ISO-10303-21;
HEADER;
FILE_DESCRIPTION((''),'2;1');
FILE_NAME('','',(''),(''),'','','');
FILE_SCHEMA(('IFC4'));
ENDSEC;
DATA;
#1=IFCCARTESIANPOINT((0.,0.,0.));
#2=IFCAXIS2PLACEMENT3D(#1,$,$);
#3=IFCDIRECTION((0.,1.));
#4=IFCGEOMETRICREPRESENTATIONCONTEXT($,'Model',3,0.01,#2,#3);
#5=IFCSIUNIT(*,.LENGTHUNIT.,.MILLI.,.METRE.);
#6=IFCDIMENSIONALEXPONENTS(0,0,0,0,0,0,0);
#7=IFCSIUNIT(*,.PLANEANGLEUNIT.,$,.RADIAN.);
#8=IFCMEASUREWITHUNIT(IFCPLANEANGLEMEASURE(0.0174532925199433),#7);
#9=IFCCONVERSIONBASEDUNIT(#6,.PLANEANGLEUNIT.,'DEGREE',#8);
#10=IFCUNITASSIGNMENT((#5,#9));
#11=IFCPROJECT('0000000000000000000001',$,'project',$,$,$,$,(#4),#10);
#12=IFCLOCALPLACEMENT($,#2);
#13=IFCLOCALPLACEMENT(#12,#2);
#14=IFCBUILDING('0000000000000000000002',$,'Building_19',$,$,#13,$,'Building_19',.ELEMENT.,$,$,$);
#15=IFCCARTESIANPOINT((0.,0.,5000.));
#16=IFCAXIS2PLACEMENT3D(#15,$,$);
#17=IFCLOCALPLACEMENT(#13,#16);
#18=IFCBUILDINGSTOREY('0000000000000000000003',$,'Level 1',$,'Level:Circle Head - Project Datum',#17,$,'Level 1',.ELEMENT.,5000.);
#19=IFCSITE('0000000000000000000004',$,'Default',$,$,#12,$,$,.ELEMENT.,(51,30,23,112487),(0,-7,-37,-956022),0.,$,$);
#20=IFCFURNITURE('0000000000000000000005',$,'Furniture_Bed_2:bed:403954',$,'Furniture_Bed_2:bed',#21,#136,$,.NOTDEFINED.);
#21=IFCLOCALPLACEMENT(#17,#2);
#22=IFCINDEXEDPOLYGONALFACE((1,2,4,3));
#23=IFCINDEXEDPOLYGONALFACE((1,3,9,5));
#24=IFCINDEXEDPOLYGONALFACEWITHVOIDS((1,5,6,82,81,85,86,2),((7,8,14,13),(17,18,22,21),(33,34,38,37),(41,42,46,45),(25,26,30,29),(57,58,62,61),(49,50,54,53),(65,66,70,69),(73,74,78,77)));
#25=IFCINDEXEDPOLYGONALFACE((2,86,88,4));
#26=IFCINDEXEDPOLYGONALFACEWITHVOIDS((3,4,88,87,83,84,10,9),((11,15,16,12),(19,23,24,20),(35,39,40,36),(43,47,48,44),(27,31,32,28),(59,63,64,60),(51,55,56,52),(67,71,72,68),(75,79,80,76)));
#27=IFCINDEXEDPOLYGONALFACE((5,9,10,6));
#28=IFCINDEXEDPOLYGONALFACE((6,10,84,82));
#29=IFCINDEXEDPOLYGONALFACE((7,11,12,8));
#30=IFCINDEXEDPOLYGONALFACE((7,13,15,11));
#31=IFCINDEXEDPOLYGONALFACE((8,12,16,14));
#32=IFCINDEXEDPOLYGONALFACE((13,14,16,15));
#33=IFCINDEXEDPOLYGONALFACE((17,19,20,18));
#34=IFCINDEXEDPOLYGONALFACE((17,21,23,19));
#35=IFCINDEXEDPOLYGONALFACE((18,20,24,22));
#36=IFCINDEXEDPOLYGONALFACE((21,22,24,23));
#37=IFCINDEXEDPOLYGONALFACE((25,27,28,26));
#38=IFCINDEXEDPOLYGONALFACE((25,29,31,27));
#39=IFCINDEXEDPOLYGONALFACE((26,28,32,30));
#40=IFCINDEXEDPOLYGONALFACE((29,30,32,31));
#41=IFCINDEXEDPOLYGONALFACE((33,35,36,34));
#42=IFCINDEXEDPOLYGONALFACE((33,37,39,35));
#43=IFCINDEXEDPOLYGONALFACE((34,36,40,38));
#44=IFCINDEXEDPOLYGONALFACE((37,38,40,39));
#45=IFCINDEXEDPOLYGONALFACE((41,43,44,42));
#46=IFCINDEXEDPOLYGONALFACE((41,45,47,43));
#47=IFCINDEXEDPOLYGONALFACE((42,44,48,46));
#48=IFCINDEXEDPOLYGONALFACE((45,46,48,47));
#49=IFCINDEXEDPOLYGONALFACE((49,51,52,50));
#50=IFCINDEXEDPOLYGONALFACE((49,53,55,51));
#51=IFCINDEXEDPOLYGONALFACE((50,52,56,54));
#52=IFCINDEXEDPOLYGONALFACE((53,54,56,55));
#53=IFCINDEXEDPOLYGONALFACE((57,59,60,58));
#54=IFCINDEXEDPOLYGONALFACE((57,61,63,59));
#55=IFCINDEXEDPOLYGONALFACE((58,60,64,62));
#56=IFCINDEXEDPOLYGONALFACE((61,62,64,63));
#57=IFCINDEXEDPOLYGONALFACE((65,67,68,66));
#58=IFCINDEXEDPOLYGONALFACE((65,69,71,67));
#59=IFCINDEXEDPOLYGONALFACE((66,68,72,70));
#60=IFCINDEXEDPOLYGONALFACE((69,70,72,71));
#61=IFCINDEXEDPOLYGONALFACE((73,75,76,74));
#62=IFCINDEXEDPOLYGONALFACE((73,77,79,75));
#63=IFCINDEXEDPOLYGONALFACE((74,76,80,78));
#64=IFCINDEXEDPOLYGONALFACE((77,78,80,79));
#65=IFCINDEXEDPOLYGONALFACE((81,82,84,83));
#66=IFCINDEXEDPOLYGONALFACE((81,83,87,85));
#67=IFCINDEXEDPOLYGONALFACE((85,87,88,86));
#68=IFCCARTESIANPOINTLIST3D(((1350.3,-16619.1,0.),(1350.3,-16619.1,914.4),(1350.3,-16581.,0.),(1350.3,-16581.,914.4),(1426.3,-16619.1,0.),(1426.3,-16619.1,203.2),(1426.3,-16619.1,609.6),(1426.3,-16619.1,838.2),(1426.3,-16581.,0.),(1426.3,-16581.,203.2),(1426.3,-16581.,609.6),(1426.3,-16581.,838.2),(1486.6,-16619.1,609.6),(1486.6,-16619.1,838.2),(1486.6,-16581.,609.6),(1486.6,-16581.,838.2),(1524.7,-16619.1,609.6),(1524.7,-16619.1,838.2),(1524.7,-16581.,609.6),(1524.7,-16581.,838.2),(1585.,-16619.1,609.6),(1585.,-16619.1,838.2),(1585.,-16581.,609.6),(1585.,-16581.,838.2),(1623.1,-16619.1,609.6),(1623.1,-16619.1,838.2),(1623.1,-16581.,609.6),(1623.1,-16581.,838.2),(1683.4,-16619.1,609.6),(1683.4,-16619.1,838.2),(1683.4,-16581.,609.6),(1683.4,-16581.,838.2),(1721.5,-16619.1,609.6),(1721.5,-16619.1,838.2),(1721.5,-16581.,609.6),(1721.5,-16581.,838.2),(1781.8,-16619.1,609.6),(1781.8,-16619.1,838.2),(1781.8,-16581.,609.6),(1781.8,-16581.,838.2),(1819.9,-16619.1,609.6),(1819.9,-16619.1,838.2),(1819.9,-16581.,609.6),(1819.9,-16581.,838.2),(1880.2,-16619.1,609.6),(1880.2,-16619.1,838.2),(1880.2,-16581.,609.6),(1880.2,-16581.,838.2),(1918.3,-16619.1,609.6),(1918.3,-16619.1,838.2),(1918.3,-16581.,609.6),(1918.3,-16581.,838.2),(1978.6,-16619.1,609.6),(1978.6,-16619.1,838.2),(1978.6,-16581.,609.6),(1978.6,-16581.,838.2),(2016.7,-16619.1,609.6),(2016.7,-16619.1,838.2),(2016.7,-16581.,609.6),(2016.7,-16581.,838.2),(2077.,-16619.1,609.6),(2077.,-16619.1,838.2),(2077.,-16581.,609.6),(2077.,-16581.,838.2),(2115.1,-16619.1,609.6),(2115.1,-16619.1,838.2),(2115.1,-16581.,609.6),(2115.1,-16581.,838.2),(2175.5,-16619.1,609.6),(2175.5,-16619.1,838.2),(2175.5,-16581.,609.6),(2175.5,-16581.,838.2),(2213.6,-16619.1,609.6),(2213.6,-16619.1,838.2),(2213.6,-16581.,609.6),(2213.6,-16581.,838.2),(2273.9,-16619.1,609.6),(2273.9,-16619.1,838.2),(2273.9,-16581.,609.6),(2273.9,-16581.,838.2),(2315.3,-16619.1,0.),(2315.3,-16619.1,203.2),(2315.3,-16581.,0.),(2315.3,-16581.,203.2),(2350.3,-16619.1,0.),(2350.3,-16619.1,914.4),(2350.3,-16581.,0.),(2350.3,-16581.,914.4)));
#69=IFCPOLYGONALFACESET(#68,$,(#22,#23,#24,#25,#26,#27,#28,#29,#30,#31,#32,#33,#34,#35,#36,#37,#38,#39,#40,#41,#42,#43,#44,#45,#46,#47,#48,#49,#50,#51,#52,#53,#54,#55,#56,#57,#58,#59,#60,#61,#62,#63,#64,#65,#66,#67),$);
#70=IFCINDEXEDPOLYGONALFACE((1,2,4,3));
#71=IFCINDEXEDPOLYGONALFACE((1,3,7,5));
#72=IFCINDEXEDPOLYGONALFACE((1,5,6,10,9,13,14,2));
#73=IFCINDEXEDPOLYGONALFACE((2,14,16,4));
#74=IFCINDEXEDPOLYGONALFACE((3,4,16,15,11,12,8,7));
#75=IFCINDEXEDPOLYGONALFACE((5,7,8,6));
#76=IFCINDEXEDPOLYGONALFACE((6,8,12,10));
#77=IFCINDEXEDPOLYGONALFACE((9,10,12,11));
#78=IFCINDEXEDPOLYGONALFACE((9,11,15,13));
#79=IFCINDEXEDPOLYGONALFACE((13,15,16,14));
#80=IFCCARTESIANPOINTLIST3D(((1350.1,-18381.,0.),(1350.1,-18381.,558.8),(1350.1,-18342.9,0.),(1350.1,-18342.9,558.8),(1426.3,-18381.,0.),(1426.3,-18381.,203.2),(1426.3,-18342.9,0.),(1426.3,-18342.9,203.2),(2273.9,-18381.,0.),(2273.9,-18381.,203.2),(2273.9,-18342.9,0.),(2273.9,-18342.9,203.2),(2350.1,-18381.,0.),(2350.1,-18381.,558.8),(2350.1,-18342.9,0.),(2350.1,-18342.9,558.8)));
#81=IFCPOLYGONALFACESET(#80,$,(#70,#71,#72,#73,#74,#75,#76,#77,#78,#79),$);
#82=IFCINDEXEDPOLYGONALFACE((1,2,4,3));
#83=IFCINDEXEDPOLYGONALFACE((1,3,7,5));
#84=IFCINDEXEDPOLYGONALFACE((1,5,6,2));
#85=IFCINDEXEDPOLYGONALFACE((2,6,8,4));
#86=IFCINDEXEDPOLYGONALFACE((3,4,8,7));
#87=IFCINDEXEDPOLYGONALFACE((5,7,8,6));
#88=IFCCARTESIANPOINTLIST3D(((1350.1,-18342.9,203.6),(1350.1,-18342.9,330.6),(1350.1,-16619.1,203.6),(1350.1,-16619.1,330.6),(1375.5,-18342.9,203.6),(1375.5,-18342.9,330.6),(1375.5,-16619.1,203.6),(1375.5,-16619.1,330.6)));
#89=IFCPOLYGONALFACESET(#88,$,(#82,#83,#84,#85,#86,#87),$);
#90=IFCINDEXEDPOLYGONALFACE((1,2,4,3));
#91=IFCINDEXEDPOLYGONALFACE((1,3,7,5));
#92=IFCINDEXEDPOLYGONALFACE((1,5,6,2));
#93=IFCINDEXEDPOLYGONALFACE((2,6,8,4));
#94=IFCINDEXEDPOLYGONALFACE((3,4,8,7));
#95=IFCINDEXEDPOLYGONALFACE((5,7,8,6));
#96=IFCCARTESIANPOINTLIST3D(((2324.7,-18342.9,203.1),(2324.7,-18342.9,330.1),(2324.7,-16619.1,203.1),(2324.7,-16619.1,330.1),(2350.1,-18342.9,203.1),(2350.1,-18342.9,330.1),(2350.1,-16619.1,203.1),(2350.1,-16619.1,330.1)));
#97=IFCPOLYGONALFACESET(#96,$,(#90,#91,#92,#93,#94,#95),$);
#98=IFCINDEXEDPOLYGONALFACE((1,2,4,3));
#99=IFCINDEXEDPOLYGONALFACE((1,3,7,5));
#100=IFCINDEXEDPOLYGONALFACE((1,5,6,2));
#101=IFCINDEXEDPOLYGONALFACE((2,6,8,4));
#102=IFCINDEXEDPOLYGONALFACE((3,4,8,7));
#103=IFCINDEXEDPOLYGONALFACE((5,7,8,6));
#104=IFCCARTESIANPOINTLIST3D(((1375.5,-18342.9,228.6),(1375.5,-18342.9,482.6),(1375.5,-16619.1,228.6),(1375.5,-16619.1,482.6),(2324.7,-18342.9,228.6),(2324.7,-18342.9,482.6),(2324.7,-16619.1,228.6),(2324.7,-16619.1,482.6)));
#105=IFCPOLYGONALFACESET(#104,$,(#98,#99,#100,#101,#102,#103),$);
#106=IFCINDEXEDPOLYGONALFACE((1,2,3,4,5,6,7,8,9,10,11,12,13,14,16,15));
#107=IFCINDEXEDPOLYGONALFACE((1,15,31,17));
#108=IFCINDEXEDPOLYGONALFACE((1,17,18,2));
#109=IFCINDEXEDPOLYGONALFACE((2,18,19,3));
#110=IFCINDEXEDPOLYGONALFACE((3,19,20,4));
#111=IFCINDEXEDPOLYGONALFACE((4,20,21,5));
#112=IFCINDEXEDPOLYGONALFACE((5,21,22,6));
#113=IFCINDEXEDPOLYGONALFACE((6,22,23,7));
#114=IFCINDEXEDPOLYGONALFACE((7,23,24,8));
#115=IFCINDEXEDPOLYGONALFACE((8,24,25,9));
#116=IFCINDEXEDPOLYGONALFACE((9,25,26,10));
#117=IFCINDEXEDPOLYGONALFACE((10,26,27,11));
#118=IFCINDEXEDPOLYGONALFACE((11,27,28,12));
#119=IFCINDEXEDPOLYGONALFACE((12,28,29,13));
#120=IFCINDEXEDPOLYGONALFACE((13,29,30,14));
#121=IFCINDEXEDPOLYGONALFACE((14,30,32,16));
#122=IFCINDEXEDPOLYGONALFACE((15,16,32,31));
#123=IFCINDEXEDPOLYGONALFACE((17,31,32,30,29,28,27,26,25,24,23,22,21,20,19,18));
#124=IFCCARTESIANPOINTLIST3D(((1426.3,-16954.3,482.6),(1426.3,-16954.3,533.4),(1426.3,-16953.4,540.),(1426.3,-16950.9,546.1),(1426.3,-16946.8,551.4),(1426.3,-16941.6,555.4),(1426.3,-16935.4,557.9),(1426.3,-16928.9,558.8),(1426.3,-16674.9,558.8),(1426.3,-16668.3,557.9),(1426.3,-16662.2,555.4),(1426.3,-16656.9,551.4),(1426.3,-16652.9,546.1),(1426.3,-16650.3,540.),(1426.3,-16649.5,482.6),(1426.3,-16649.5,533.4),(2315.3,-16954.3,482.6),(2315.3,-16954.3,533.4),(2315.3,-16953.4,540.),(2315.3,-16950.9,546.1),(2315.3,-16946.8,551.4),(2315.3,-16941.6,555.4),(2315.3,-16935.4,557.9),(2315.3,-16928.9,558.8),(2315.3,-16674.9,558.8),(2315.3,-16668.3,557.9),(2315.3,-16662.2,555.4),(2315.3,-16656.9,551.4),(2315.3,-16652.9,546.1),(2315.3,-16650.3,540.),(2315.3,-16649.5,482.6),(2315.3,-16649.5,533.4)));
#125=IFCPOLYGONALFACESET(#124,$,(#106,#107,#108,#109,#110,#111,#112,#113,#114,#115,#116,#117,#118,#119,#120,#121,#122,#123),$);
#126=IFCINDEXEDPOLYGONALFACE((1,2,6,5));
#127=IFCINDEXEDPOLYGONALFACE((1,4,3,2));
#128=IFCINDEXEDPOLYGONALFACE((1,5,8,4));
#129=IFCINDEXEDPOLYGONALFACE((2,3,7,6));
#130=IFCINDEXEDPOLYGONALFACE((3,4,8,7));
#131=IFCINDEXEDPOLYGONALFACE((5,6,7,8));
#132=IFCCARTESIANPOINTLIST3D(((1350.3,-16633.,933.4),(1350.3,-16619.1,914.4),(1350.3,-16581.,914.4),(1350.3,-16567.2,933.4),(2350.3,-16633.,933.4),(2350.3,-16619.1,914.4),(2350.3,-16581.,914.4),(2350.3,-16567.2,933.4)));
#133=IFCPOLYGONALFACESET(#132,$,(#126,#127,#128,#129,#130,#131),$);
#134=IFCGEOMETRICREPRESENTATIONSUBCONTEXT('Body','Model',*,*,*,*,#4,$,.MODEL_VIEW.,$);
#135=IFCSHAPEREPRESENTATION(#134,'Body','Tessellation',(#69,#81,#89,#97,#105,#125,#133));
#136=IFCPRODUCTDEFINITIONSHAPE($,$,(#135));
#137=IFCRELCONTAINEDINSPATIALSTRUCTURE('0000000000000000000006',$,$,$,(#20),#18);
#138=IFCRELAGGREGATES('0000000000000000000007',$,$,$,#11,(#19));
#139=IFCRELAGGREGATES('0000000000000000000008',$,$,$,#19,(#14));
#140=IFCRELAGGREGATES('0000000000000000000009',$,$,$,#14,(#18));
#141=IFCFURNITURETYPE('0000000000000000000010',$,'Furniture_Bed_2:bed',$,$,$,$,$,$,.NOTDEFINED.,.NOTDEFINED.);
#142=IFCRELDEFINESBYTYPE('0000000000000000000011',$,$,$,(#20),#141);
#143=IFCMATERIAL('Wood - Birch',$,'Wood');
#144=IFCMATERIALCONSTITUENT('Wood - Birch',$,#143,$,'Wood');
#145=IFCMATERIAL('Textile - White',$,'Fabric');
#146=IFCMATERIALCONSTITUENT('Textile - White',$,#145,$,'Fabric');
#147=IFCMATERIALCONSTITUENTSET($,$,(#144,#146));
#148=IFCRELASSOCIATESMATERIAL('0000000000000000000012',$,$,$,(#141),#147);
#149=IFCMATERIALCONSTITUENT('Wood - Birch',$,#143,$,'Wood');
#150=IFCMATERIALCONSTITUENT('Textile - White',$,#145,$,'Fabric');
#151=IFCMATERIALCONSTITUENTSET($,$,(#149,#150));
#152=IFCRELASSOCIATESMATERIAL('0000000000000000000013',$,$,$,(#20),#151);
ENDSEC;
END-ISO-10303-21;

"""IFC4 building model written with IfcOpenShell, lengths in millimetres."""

from ifc_helpers import new_model, entity, si_unit, converted_unit, direction, frame, origin, place, context, subcontext, project, spatial, line, arc, indexed_curve, outline, extrude, source, transform, mapped, material, constituent, constituent_set, type_object, type_shapes, element, save


model = new_model("IFC4")

# Units and contexts
model_context = context("Model", 3, precision=0.01, world=origin(), true_north=direction((0.0, 1.0)))
body_context = subcontext(model_context, "Body", "Model", "MODEL_VIEW")
ifc_project = project(units=[si_unit("LENGTHUNIT", "METRE", prefix="MILLI"), converted_unit("PLANEANGLEUNIT", "DEGREE", entity("IfcPlaneAngleMeasure", 0.0174532925199433), si_unit("PLANEANGLEUNIT", "RADIAN"), dimensions=[0, 0, 0, 0, 0, 0, 0])], contexts=[model_context])

# Site, building, storey
site_placement = place(None, origin())
site = spatial("IfcSite", under=ifc_project, at=site_placement, Name="Default", CompositionType="ELEMENT", RefLatitude=(51, 30, 23, 112487), RefLongitude=(0, -7, -37, -956022), RefElevation=0.0)
building_placement = place(site_placement, origin())
building = spatial("IfcBuilding", under=site, at=building_placement, Name="Building_19", LongName="Building_19", CompositionType="ELEMENT")
storey_placement = place(building_placement, frame((0.0, 0.0, 5000.0)))
storey = spatial("IfcBuildingStorey", under=building, at=storey_placement, Name="Level 1", ObjectType="Level:Circle Head - Project Datum", LongName="Level 1", CompositionType="ELEMENT", Elevation=5000.0)

# Furniture
ifc_material_1 = material(Name="Wood - Birch", Category="Wood")
ifc_material_2 = material(Name="Textile - White", Category="Fabric")
ifc_constituent_1 = constituent(ifc_material_1, Name="Wood - Birch", Category="Wood")
ifc_constituent_2 = constituent(ifc_material_2, Name="Textile - White", Category="Fabric")
ifc_constituent_set_1 = constituent_set(constituents=[ifc_constituent_1, ifc_constituent_2])
furniture_type_1 = type_object("IfcFurnitureType", Name="Furniture_Bed_2:bed", AssemblyPlace="NOTDEFINED", PredefinedType="NOTDEFINED", material=ifc_constituent_set_1)
shared_shape_1 = source(origin(), body_context, "Body", "SweptSolid", [
    extrude(outline(indexed_curve([(-635.0, -489.8), (279.4, -489.8), (279.4, -454.7), (76.2, -454.7), (76.2, 434.3), (279.4, 434.3), (279.4, 510.3), (-635.0, 510.3), (-635.0, -489.8)], self_intersect=False), holes=[indexed_curve([(-558.8, 374.0), (-558.8, 434.3), (-330.2, 434.3), (-330.2, 374.0), (-558.8, 374.0)], self_intersect=False), indexed_curve([(-558.8, 275.5), (-558.8, 335.9), (-330.2, 335.9), (-330.2, 275.5), (-558.8, 275.5)], self_intersect=False), indexed_curve([(-558.8, 177.1), (-558.8, 237.4), (-330.2, 237.4), (-330.2, 177.1), (-558.8, 177.1)], self_intersect=False), indexed_curve([(-558.8, 78.7), (-558.8, 139.0), (-330.2, 139.0), (-330.2, 78.7), (-558.8, 78.7)], self_intersect=False), indexed_curve([(-558.8, -118.1), (-558.8, -57.8), (-330.2, -57.8), (-330.2, -118.1), (-558.8, -118.1)], self_intersect=False), indexed_curve([(-558.8, -216.5), (-558.8, -156.2), (-330.2, -156.2), (-330.2, -216.5), (-558.8, -216.5)], self_intersect=False), indexed_curve([(-558.8, -314.9), (-558.8, -254.6), (-330.2, -254.6), (-330.2, -314.9), (-558.8, -314.9)], self_intersect=False), indexed_curve([(-558.8, -413.3), (-558.8, -353.0), (-330.2, -353.0), (-330.2, -413.3), (-558.8, -413.3)], self_intersect=False), indexed_curve([(-558.8, -19.7), (-558.8, 40.6), (-330.2, 40.6), (-330.2, -19.7), (-558.8, -19.7)], self_intersect=False)]), frame((-8.6, -38.1, 279.4), z_axis=(0.0, 1.0, 0.0), x_axis=(0.0, 0.0, -1.0)), (0.0, 0.0, 1.0), 38.1),
    extrude(outline(indexed_curve([(423.8, -190.5), (500.0, -190.5), (500.0, 368.3), (-500.0, 368.3), (-500.0, -190.5), (-423.8, -190.5), (-423.8, 12.7), (423.8, 12.7), (423.8, -190.5)], self_intersect=False)), frame((-19.1, -1800.0, 190.5), z_axis=(0.0, 1.0, 0.0), x_axis=(-1.0, 0.0, 0.0)), (0.0, 0.0, 1.0), 38.1),
    extrude(outline(indexed_curve([(-12.7, -861.9), (12.7, -861.9), (12.7, 861.9), (-12.7, 861.9), (-12.7, -861.9)], self_intersect=False)), frame((-506.4, -900.0, 203.6)), (0.0, 0.0, 1.0), 127.0),
    extrude(outline(indexed_curve([(-12.7, -861.9), (12.7, -861.9), (12.7, 861.9), (-12.7, 861.9), (-12.7, -861.9)], self_intersect=False)), frame((468.2, -900.0, 203.1)), (0.0, 0.0, 1.0), 127.0),
    extrude(outline(indexed_curve([(-474.6, -861.9), (474.6, -861.9), (474.6, 861.9), (-474.6, 861.9), (-474.6, -861.9)], self_intersect=False)), frame((-19.0, -900.0, 228.6), z_axis=(0.0, 0.0, 1.0), x_axis=(-1.0, 0.0, 0.0)), (0.0, 0.0, 1.0), 254.0),
    extrude(outline(indexed_curve([(-152.4, -42.3), (152.4, -42.3), (152.4, 8.5), (145.0, 26.4), (127.0, 33.9), (-127.0, 33.9), (-145.0, 26.4), (-152.4, 8.5)], segments=[line(1, 2, 3), arc(3, 4, 5), line(5, 6), arc(6, 7, 8), line(8, 1)], self_intersect=False)), frame((-442.9, -220.8, 524.9), z_axis=(1.0, 0.0, 0.0), x_axis=(0.0, 1.0, 0.0)), (0.0, 0.0, 1.0), 889.0),
    extrude(outline(indexed_curve([(-19.1, -9.5), (19.0, -9.5), (32.9, 9.5), (-32.9, 9.5), (-19.1, -9.5)], self_intersect=False)), frame((-518.8, -19.0, 923.9), z_axis=(1.0, 0.0, 0.0), x_axis=(0.0, 1.0, 0.0)), (0.0, 0.0, 1.0), 1000.1),
])
type_shapes(furniture_type_1, [shared_shape_1])
ifc_constituent_3 = constituent(ifc_material_1, Name="Wood - Birch", Category="Wood")
ifc_constituent_4 = constituent(ifc_material_2, Name="Textile - White", Category="Fabric")
ifc_constituent_set_2 = constituent_set(constituents=[ifc_constituent_3, ifc_constituent_4])
furniture_1_placement = place(storey_placement, frame((1869.1, -16581.0, 0.0)))
element("IfcFurniture", 1, at=furniture_1_placement, inside=storey, type_object=furniture_type_1, material=ifc_constituent_set_2, Name="Furniture_Bed_2:bed:403954", ObjectType="Furniture_Bed_2:bed", PredefinedType="NOTDEFINED", context=body_context, shape_type="MappedRepresentation", body=[
    mapped(shared_shape_1, transform((0.0, 0.0, 0.0), scale=1.0)),
])

save(model, "model.ifc")
